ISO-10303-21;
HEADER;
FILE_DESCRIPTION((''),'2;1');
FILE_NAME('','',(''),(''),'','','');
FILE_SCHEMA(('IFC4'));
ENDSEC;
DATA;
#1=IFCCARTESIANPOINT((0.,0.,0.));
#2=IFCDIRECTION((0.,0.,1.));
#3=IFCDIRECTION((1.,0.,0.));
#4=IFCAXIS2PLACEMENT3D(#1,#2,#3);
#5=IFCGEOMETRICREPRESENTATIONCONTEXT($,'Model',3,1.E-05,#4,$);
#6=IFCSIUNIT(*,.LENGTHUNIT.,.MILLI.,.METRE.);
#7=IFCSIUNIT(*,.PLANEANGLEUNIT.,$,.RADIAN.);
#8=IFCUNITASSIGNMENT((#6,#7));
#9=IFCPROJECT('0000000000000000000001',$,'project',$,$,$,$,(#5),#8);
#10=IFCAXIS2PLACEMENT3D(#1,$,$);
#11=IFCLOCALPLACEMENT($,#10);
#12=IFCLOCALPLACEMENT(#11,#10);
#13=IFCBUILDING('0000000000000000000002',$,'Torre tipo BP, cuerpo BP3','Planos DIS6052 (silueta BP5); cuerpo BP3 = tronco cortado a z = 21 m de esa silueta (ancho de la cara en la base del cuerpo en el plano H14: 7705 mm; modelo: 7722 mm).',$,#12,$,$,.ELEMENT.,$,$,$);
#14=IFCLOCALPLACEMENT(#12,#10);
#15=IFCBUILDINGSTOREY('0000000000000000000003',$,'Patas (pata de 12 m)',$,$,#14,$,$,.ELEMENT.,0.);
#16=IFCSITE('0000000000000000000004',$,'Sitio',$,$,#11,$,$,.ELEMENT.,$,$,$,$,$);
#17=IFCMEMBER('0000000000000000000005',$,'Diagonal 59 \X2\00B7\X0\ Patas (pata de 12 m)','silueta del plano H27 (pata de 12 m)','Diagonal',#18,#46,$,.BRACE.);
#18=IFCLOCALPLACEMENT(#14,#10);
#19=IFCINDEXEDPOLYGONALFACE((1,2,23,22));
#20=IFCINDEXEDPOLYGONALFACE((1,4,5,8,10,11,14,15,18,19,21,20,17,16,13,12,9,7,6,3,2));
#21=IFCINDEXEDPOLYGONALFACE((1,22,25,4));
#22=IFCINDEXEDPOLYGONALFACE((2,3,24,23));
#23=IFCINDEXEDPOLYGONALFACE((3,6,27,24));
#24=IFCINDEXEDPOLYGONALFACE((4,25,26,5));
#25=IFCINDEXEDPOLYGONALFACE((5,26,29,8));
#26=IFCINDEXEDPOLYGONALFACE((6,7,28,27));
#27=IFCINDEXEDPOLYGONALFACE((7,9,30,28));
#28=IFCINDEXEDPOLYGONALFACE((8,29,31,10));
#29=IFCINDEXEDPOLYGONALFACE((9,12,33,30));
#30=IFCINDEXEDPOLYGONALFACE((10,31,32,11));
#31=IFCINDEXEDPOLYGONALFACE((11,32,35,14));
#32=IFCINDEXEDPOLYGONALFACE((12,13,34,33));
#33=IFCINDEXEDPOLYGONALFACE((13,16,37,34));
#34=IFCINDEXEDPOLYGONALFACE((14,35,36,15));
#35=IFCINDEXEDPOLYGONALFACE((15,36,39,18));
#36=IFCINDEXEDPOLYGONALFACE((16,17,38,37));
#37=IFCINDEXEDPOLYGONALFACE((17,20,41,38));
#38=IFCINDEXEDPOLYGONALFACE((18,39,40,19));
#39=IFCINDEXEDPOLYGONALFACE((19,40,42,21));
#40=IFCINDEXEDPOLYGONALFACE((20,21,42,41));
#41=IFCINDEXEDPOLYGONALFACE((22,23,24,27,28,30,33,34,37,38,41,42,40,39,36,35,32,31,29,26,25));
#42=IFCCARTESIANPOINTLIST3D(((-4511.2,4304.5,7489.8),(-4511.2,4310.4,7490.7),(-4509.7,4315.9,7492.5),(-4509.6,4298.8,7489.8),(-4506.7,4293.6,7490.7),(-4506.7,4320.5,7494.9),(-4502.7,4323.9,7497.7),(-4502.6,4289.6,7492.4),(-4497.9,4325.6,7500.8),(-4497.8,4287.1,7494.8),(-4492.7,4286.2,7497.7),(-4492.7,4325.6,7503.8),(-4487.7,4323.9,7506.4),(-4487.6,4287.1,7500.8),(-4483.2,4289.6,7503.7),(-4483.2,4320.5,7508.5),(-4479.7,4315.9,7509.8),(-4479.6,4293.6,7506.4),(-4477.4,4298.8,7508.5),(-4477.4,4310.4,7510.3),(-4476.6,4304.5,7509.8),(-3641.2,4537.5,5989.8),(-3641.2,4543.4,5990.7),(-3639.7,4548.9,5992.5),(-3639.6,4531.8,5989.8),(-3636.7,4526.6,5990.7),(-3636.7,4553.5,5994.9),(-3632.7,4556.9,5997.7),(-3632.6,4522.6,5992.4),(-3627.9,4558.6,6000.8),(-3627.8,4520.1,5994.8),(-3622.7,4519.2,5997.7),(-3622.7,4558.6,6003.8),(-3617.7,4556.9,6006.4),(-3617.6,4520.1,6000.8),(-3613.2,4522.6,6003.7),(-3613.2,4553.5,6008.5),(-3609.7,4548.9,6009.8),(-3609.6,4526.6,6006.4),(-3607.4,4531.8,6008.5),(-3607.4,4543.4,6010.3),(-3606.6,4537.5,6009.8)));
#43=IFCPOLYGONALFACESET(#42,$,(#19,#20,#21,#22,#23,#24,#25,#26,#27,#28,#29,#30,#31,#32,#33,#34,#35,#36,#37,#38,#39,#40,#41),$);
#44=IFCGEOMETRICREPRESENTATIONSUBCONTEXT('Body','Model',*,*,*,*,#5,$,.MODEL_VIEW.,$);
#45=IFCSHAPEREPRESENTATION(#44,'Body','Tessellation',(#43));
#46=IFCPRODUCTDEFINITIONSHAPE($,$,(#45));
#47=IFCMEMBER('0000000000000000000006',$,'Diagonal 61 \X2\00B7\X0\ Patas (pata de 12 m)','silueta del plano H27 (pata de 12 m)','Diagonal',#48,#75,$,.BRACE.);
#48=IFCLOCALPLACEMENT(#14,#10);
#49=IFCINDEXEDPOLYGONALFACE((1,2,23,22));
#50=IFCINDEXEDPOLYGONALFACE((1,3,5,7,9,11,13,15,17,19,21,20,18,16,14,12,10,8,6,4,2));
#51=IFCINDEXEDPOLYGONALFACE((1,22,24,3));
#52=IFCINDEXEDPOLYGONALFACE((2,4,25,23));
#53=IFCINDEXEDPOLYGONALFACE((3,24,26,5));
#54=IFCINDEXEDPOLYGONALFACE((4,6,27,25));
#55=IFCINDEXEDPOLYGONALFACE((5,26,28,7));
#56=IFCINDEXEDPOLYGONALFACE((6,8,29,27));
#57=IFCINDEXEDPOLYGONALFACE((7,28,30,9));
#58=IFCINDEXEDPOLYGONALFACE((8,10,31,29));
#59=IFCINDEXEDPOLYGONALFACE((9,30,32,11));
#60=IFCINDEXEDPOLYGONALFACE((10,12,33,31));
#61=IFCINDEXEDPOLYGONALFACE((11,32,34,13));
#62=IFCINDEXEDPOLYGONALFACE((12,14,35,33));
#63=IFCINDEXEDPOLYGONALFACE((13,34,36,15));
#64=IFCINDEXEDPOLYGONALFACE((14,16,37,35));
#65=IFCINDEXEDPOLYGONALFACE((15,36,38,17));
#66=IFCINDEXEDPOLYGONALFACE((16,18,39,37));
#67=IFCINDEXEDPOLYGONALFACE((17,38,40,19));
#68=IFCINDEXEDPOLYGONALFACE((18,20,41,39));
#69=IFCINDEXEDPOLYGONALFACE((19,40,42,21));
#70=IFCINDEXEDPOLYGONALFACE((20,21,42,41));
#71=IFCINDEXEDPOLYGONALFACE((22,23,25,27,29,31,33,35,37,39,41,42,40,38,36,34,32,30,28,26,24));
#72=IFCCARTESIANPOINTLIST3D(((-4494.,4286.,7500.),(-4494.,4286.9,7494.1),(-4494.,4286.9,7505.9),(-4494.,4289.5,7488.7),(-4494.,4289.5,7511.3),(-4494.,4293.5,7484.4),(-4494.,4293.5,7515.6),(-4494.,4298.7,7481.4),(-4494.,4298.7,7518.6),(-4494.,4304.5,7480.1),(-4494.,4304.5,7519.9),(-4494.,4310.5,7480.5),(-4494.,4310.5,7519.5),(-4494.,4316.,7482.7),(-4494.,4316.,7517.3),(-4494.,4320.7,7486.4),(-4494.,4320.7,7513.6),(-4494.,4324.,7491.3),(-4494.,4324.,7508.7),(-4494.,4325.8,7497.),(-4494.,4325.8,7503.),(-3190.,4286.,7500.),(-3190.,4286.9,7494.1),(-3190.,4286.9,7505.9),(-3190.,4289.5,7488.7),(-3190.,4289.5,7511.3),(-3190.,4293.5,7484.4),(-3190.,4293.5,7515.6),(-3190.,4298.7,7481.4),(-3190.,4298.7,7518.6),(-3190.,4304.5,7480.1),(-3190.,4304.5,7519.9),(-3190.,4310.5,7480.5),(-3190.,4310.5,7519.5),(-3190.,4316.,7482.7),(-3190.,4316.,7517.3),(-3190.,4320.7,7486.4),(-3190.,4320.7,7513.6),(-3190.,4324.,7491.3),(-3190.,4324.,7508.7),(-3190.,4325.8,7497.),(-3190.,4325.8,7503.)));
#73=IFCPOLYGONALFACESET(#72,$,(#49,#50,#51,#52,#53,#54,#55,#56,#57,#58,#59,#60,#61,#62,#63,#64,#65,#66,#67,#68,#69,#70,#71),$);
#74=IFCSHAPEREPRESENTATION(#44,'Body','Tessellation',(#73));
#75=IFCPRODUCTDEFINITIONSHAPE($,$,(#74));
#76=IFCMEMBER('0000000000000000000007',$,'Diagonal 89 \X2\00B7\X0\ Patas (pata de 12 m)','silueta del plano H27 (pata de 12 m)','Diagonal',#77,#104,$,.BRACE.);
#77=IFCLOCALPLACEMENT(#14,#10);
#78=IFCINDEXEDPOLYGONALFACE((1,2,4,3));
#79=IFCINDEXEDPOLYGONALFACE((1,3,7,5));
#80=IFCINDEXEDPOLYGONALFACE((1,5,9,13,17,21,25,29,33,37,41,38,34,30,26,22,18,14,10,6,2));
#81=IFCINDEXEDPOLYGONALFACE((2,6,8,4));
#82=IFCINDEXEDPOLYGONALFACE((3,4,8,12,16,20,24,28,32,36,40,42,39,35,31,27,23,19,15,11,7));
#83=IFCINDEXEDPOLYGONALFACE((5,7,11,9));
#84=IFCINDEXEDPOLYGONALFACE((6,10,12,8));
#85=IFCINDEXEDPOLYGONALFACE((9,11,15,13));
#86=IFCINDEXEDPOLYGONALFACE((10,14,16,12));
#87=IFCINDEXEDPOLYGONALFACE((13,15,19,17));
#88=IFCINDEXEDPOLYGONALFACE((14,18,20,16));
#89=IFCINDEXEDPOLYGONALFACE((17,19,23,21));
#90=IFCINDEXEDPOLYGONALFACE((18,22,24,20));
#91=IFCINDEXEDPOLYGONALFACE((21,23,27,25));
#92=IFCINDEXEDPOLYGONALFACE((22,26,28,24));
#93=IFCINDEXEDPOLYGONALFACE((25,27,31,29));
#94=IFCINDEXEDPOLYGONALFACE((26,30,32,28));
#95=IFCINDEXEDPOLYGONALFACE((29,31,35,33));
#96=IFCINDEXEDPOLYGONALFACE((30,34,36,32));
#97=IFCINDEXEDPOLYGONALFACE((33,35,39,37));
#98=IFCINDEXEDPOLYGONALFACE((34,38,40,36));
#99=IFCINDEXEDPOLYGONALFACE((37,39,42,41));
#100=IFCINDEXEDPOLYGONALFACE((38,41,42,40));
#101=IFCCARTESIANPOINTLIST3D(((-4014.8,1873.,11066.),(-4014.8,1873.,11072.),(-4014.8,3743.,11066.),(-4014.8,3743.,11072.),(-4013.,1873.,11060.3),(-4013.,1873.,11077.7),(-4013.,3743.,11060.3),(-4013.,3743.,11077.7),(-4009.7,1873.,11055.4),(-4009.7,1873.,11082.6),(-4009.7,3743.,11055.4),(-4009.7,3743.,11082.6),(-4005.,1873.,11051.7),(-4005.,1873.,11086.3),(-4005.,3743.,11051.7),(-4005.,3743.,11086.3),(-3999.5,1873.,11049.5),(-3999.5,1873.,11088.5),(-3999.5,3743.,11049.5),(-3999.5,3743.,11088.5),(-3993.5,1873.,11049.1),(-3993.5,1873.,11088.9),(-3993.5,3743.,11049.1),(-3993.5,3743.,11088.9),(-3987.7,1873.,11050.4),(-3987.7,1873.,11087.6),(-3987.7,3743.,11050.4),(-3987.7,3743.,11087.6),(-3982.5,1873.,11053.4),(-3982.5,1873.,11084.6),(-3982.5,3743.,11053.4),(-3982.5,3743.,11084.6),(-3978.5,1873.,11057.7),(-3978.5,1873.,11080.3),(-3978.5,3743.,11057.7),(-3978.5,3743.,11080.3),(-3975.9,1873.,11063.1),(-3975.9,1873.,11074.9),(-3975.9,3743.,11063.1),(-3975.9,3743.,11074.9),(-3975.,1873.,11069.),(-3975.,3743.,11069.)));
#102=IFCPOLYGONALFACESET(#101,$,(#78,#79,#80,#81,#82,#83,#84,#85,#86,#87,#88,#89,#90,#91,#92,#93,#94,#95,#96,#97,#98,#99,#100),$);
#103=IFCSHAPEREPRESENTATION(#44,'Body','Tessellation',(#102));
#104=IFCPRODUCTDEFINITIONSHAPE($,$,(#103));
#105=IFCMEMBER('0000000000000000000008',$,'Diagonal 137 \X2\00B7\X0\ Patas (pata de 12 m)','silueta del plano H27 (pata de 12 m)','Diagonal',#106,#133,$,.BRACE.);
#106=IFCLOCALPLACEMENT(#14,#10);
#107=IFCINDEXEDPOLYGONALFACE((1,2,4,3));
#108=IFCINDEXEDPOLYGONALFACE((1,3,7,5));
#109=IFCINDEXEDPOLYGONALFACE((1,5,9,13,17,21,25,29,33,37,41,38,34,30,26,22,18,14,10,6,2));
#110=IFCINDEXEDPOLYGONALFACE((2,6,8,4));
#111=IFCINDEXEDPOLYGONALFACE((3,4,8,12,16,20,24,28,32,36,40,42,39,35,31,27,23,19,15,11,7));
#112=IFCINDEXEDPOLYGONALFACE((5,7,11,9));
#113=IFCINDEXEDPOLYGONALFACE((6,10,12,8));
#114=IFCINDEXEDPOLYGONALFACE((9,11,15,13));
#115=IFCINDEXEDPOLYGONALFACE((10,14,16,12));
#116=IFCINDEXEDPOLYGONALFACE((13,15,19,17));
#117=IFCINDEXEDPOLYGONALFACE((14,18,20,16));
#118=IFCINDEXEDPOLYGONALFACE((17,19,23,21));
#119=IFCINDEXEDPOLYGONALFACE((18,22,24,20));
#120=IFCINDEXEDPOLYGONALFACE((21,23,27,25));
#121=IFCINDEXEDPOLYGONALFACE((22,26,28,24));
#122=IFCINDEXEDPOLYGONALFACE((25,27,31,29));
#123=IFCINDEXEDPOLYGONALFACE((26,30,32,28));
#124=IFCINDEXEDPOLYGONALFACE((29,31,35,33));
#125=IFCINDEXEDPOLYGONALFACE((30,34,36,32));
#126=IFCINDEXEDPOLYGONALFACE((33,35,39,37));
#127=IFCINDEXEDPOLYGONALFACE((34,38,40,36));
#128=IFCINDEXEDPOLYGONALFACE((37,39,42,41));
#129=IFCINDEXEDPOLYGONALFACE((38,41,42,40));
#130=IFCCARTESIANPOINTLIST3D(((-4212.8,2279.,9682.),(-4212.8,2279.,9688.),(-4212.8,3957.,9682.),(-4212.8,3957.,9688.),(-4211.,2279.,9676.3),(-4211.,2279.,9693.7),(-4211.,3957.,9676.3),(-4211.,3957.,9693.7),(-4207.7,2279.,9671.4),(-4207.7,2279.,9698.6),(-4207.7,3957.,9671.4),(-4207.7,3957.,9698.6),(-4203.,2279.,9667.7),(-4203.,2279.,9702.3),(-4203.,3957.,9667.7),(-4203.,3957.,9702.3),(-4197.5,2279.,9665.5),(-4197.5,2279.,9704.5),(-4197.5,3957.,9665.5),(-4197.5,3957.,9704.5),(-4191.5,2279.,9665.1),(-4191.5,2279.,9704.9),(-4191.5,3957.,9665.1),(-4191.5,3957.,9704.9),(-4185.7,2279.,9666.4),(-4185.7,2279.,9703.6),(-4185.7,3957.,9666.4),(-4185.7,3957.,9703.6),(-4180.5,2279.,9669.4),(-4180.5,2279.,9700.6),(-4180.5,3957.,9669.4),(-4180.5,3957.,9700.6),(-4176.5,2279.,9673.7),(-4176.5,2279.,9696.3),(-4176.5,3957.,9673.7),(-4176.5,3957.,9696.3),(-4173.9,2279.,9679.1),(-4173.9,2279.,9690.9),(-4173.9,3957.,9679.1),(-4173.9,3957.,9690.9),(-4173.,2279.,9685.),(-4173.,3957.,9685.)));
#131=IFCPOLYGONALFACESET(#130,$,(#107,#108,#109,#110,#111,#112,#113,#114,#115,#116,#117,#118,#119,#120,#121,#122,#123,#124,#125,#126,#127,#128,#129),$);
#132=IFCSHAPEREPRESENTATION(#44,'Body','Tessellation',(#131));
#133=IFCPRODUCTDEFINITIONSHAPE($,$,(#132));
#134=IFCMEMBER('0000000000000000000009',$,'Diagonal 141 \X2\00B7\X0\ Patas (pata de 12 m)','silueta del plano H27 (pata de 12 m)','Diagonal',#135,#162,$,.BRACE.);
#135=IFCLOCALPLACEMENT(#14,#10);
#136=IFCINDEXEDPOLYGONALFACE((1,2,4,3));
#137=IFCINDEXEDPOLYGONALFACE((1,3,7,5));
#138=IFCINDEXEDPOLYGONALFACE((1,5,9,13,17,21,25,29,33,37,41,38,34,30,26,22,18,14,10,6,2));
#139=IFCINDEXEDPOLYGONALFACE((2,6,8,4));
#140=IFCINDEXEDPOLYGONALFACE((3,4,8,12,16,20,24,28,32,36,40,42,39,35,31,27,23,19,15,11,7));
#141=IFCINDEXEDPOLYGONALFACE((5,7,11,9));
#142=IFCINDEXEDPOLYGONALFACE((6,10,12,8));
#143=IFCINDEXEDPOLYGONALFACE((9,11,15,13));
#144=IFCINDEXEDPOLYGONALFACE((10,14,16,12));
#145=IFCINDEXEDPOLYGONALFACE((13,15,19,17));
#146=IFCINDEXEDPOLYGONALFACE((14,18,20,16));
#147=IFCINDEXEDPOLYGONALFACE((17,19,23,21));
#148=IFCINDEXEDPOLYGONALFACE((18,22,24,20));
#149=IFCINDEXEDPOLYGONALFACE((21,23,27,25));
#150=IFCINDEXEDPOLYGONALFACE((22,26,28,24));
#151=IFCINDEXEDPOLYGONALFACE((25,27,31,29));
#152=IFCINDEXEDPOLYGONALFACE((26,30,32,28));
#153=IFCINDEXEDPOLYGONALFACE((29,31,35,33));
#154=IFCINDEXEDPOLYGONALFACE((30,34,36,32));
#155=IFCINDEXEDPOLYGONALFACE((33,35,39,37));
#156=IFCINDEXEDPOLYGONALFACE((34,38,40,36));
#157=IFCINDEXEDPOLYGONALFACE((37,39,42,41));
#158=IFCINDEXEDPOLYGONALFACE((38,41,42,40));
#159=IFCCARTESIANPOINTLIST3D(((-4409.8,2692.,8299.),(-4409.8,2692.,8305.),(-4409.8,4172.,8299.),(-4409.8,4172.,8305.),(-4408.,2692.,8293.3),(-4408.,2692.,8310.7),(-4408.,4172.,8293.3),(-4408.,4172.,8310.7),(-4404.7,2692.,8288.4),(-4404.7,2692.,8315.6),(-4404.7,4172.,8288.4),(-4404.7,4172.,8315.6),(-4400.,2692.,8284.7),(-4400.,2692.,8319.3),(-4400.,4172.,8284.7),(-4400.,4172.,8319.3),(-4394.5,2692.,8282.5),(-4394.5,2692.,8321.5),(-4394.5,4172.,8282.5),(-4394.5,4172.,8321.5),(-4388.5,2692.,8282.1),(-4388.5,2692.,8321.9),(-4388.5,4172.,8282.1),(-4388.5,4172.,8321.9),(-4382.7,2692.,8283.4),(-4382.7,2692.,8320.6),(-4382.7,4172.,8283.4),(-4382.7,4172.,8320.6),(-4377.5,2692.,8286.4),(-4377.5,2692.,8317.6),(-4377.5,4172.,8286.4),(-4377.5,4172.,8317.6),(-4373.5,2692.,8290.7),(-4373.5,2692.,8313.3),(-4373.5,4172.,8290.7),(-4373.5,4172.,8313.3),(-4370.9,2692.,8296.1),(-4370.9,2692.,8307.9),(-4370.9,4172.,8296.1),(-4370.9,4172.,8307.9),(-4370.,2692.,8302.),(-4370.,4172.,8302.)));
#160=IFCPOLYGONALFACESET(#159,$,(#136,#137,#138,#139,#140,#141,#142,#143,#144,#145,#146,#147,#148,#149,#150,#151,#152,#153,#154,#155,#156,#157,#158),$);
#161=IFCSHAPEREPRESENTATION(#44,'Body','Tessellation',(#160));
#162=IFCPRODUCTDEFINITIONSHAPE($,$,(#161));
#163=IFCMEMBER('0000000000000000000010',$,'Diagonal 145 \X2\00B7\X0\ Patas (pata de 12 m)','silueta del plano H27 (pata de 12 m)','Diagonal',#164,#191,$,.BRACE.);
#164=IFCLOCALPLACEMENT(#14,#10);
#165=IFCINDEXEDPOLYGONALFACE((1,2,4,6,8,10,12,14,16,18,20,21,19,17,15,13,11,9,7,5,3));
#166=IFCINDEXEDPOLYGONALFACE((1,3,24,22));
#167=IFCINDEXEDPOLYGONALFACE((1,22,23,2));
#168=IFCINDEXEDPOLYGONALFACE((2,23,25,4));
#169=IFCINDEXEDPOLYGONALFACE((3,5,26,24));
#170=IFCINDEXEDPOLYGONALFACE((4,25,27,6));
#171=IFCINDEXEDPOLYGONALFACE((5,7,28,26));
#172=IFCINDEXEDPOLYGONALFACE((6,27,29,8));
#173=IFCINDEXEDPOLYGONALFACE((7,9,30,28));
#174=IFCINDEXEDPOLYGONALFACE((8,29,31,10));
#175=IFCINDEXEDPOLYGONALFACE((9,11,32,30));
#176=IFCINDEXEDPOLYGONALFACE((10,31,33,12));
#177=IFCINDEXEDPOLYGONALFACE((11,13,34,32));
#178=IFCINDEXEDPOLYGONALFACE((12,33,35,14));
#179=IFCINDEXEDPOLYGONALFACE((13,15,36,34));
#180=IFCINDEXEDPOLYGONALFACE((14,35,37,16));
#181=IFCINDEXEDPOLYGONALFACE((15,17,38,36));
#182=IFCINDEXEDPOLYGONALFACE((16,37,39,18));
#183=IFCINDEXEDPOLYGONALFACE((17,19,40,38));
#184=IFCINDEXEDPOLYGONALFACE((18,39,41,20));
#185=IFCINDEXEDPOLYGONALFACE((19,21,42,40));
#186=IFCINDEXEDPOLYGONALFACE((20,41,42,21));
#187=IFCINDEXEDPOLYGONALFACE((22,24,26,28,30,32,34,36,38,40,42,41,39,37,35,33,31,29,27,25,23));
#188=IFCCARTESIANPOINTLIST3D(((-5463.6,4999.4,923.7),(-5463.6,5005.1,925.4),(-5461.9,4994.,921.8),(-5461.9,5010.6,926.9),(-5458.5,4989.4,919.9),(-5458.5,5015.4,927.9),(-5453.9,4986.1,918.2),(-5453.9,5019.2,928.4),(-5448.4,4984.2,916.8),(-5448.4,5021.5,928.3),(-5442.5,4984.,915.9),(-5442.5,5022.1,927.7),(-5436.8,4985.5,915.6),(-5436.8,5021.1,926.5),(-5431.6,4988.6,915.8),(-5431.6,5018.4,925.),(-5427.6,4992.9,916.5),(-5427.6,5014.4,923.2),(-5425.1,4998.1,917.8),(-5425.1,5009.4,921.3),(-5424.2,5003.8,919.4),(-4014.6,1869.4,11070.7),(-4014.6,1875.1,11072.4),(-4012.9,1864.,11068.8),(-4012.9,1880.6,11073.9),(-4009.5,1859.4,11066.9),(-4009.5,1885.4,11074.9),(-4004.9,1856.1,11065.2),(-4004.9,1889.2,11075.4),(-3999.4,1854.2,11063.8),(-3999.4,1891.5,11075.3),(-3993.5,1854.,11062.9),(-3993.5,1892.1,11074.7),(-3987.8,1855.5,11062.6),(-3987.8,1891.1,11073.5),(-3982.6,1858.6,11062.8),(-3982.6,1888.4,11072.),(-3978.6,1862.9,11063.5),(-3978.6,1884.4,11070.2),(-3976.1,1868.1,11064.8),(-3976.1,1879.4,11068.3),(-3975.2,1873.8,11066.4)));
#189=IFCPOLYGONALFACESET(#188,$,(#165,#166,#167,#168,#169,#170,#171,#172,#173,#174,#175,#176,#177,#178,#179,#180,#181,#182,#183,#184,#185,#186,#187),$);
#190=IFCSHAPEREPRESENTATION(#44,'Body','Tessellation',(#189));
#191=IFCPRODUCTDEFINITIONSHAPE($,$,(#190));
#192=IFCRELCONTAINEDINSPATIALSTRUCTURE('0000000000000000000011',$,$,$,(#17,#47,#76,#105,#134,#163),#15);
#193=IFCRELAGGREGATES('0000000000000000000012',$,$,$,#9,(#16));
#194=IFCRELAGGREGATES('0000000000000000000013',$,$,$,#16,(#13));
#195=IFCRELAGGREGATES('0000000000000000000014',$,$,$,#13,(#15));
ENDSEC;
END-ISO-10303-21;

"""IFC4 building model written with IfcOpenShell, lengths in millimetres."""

from ifc_helpers import new_model, si_unit, frame, origin, origin_with_axes, place, context, subcontext, project, spatial, circle, extrude, element, save


model = new_model("IFC4")

# Units and contexts
model_context = context("Model", 3, precision=1e-05, world=origin_with_axes())
body_context = subcontext(model_context, "Body", "Model", "MODEL_VIEW")
ifc_project = project(units=[si_unit("LENGTHUNIT", "METRE", prefix="MILLI"), si_unit("PLANEANGLEUNIT", "RADIAN")], contexts=[model_context])

# Site, building, storey
site_placement = place(None, origin())
site = spatial("IfcSite", under=ifc_project, at=site_placement, Name="Sitio", CompositionType="ELEMENT")
building_placement = place(site_placement, origin())
building = spatial("IfcBuilding", under=site, at=building_placement, Name="Torre tipo BP, cuerpo BP3", Description="Planos DIS6052 (silueta BP5); cuerpo BP3 = tronco cortado a z = 21 m de esa silueta (ancho de la cara en la base del cuerpo en el plano H14: 7705 mm; modelo: 7722 mm).", CompositionType="ELEMENT")
storey_placement = place(building_placement, origin())
storey = spatial("IfcBuildingStorey", under=building, at=storey_placement, Name="Patas (pata de 12 m)", CompositionType="ELEMENT", Elevation=0.0)

# Members
member_1_placement = place(storey_placement, frame((-3624.0, 4539.0, 6000.0), z_axis=(-0.497249, -0.133171, 0.857326), x_axis=(0.066814, -0.991093, -0.115197)))
element("IfcMember", 1, at=member_1_placement, inside=storey, Name="Diagonal 59 · Patas (pata de 12 m)", Description="silueta del plano H27 (pata de 12 m)", ObjectType="Diagonal", PredefinedType="BRACE", context=body_context, shape_type="SweptSolid", body=[
    extrude(circle(Radius=20.0), None, (0.0, 0.0, 1.0), 1749.6),
])
member_2_placement = place(storey_placement, frame((-4494.0, 4306.0, 7500.0), z_axis=(1.0, 0.0, 0.0), x_axis=(0.0, -1.0, 0.0)))
element("IfcMember", 2, at=member_2_placement, inside=storey, Name="Diagonal 61 · Patas (pata de 12 m)", Description="silueta del plano H27 (pata de 12 m)", ObjectType="Diagonal", PredefinedType="BRACE", context=body_context, shape_type="SweptSolid", body=[
    extrude(circle(Radius=20.0), None, (0.0, 0.0, 1.0), 1304.0),
])
member_3_placement = place(storey_placement, frame((-3995.0, 3743.0, 11069.0), z_axis=(0.0, -1.0, 0.0), x_axis=(1.0, 0.0, 0.0)))
element("IfcMember", 3, at=member_3_placement, inside=storey, Name="Diagonal 89 · Patas (pata de 12 m)", Description="silueta del plano H27 (pata de 12 m)", ObjectType="Diagonal", PredefinedType="BRACE", context=body_context, shape_type="SweptSolid", body=[
    extrude(circle(Radius=20.0), None, (0.0, 0.0, 1.0), 1870.0),
])
member_4_placement = place(storey_placement, frame((-4193.0, 2279.0, 9685.0), z_axis=(0.0, 1.0, 0.0), x_axis=(1.0, 0.0, 0.0)))
element("IfcMember", 4, at=member_4_placement, inside=storey, Name="Diagonal 137 · Patas (pata de 12 m)", Description="silueta del plano H27 (pata de 12 m)", ObjectType="Diagonal", PredefinedType="BRACE", context=body_context, shape_type="SweptSolid", body=[
    extrude(circle(Radius=20.0), None, (0.0, 0.0, 1.0), 1678.0),
])
member_5_placement = place(storey_placement, frame((-4390.0, 4172.0, 8302.0), z_axis=(0.0, -1.0, 0.0), x_axis=(1.0, 0.0, 0.0)))
element("IfcMember", 5, at=member_5_placement, inside=storey, Name="Diagonal 141 · Patas (pata de 12 m)", Description="silueta del plano H27 (pata de 12 m)", ObjectType="Diagonal", PredefinedType="BRACE", context=body_context, shape_type="SweptSolid", body=[
    extrude(circle(Radius=20.0), None, (0.0, 0.0, 1.0), 1480.0),
])
member_6_placement = place(storey_placement, frame((-3995.0, 1873.0, 11069.0), z_axis=(-0.135203, 0.292054, -0.946797), x_axis=(0.990818, 0.039853, -0.129196)))
element("IfcMember", 6, at=member_6_placement, inside=storey, Name="Diagonal 145 · Patas (pata de 12 m)", Description="silueta del plano H27 (pata de 12 m)", ObjectType="Diagonal", PredefinedType="BRACE", context=body_context, shape_type="SweptSolid", body=[
    extrude(circle(Radius=20.0), None, (0.0, 0.0, 1.0), 10717.2),
])

save(model, "model.ifc")
